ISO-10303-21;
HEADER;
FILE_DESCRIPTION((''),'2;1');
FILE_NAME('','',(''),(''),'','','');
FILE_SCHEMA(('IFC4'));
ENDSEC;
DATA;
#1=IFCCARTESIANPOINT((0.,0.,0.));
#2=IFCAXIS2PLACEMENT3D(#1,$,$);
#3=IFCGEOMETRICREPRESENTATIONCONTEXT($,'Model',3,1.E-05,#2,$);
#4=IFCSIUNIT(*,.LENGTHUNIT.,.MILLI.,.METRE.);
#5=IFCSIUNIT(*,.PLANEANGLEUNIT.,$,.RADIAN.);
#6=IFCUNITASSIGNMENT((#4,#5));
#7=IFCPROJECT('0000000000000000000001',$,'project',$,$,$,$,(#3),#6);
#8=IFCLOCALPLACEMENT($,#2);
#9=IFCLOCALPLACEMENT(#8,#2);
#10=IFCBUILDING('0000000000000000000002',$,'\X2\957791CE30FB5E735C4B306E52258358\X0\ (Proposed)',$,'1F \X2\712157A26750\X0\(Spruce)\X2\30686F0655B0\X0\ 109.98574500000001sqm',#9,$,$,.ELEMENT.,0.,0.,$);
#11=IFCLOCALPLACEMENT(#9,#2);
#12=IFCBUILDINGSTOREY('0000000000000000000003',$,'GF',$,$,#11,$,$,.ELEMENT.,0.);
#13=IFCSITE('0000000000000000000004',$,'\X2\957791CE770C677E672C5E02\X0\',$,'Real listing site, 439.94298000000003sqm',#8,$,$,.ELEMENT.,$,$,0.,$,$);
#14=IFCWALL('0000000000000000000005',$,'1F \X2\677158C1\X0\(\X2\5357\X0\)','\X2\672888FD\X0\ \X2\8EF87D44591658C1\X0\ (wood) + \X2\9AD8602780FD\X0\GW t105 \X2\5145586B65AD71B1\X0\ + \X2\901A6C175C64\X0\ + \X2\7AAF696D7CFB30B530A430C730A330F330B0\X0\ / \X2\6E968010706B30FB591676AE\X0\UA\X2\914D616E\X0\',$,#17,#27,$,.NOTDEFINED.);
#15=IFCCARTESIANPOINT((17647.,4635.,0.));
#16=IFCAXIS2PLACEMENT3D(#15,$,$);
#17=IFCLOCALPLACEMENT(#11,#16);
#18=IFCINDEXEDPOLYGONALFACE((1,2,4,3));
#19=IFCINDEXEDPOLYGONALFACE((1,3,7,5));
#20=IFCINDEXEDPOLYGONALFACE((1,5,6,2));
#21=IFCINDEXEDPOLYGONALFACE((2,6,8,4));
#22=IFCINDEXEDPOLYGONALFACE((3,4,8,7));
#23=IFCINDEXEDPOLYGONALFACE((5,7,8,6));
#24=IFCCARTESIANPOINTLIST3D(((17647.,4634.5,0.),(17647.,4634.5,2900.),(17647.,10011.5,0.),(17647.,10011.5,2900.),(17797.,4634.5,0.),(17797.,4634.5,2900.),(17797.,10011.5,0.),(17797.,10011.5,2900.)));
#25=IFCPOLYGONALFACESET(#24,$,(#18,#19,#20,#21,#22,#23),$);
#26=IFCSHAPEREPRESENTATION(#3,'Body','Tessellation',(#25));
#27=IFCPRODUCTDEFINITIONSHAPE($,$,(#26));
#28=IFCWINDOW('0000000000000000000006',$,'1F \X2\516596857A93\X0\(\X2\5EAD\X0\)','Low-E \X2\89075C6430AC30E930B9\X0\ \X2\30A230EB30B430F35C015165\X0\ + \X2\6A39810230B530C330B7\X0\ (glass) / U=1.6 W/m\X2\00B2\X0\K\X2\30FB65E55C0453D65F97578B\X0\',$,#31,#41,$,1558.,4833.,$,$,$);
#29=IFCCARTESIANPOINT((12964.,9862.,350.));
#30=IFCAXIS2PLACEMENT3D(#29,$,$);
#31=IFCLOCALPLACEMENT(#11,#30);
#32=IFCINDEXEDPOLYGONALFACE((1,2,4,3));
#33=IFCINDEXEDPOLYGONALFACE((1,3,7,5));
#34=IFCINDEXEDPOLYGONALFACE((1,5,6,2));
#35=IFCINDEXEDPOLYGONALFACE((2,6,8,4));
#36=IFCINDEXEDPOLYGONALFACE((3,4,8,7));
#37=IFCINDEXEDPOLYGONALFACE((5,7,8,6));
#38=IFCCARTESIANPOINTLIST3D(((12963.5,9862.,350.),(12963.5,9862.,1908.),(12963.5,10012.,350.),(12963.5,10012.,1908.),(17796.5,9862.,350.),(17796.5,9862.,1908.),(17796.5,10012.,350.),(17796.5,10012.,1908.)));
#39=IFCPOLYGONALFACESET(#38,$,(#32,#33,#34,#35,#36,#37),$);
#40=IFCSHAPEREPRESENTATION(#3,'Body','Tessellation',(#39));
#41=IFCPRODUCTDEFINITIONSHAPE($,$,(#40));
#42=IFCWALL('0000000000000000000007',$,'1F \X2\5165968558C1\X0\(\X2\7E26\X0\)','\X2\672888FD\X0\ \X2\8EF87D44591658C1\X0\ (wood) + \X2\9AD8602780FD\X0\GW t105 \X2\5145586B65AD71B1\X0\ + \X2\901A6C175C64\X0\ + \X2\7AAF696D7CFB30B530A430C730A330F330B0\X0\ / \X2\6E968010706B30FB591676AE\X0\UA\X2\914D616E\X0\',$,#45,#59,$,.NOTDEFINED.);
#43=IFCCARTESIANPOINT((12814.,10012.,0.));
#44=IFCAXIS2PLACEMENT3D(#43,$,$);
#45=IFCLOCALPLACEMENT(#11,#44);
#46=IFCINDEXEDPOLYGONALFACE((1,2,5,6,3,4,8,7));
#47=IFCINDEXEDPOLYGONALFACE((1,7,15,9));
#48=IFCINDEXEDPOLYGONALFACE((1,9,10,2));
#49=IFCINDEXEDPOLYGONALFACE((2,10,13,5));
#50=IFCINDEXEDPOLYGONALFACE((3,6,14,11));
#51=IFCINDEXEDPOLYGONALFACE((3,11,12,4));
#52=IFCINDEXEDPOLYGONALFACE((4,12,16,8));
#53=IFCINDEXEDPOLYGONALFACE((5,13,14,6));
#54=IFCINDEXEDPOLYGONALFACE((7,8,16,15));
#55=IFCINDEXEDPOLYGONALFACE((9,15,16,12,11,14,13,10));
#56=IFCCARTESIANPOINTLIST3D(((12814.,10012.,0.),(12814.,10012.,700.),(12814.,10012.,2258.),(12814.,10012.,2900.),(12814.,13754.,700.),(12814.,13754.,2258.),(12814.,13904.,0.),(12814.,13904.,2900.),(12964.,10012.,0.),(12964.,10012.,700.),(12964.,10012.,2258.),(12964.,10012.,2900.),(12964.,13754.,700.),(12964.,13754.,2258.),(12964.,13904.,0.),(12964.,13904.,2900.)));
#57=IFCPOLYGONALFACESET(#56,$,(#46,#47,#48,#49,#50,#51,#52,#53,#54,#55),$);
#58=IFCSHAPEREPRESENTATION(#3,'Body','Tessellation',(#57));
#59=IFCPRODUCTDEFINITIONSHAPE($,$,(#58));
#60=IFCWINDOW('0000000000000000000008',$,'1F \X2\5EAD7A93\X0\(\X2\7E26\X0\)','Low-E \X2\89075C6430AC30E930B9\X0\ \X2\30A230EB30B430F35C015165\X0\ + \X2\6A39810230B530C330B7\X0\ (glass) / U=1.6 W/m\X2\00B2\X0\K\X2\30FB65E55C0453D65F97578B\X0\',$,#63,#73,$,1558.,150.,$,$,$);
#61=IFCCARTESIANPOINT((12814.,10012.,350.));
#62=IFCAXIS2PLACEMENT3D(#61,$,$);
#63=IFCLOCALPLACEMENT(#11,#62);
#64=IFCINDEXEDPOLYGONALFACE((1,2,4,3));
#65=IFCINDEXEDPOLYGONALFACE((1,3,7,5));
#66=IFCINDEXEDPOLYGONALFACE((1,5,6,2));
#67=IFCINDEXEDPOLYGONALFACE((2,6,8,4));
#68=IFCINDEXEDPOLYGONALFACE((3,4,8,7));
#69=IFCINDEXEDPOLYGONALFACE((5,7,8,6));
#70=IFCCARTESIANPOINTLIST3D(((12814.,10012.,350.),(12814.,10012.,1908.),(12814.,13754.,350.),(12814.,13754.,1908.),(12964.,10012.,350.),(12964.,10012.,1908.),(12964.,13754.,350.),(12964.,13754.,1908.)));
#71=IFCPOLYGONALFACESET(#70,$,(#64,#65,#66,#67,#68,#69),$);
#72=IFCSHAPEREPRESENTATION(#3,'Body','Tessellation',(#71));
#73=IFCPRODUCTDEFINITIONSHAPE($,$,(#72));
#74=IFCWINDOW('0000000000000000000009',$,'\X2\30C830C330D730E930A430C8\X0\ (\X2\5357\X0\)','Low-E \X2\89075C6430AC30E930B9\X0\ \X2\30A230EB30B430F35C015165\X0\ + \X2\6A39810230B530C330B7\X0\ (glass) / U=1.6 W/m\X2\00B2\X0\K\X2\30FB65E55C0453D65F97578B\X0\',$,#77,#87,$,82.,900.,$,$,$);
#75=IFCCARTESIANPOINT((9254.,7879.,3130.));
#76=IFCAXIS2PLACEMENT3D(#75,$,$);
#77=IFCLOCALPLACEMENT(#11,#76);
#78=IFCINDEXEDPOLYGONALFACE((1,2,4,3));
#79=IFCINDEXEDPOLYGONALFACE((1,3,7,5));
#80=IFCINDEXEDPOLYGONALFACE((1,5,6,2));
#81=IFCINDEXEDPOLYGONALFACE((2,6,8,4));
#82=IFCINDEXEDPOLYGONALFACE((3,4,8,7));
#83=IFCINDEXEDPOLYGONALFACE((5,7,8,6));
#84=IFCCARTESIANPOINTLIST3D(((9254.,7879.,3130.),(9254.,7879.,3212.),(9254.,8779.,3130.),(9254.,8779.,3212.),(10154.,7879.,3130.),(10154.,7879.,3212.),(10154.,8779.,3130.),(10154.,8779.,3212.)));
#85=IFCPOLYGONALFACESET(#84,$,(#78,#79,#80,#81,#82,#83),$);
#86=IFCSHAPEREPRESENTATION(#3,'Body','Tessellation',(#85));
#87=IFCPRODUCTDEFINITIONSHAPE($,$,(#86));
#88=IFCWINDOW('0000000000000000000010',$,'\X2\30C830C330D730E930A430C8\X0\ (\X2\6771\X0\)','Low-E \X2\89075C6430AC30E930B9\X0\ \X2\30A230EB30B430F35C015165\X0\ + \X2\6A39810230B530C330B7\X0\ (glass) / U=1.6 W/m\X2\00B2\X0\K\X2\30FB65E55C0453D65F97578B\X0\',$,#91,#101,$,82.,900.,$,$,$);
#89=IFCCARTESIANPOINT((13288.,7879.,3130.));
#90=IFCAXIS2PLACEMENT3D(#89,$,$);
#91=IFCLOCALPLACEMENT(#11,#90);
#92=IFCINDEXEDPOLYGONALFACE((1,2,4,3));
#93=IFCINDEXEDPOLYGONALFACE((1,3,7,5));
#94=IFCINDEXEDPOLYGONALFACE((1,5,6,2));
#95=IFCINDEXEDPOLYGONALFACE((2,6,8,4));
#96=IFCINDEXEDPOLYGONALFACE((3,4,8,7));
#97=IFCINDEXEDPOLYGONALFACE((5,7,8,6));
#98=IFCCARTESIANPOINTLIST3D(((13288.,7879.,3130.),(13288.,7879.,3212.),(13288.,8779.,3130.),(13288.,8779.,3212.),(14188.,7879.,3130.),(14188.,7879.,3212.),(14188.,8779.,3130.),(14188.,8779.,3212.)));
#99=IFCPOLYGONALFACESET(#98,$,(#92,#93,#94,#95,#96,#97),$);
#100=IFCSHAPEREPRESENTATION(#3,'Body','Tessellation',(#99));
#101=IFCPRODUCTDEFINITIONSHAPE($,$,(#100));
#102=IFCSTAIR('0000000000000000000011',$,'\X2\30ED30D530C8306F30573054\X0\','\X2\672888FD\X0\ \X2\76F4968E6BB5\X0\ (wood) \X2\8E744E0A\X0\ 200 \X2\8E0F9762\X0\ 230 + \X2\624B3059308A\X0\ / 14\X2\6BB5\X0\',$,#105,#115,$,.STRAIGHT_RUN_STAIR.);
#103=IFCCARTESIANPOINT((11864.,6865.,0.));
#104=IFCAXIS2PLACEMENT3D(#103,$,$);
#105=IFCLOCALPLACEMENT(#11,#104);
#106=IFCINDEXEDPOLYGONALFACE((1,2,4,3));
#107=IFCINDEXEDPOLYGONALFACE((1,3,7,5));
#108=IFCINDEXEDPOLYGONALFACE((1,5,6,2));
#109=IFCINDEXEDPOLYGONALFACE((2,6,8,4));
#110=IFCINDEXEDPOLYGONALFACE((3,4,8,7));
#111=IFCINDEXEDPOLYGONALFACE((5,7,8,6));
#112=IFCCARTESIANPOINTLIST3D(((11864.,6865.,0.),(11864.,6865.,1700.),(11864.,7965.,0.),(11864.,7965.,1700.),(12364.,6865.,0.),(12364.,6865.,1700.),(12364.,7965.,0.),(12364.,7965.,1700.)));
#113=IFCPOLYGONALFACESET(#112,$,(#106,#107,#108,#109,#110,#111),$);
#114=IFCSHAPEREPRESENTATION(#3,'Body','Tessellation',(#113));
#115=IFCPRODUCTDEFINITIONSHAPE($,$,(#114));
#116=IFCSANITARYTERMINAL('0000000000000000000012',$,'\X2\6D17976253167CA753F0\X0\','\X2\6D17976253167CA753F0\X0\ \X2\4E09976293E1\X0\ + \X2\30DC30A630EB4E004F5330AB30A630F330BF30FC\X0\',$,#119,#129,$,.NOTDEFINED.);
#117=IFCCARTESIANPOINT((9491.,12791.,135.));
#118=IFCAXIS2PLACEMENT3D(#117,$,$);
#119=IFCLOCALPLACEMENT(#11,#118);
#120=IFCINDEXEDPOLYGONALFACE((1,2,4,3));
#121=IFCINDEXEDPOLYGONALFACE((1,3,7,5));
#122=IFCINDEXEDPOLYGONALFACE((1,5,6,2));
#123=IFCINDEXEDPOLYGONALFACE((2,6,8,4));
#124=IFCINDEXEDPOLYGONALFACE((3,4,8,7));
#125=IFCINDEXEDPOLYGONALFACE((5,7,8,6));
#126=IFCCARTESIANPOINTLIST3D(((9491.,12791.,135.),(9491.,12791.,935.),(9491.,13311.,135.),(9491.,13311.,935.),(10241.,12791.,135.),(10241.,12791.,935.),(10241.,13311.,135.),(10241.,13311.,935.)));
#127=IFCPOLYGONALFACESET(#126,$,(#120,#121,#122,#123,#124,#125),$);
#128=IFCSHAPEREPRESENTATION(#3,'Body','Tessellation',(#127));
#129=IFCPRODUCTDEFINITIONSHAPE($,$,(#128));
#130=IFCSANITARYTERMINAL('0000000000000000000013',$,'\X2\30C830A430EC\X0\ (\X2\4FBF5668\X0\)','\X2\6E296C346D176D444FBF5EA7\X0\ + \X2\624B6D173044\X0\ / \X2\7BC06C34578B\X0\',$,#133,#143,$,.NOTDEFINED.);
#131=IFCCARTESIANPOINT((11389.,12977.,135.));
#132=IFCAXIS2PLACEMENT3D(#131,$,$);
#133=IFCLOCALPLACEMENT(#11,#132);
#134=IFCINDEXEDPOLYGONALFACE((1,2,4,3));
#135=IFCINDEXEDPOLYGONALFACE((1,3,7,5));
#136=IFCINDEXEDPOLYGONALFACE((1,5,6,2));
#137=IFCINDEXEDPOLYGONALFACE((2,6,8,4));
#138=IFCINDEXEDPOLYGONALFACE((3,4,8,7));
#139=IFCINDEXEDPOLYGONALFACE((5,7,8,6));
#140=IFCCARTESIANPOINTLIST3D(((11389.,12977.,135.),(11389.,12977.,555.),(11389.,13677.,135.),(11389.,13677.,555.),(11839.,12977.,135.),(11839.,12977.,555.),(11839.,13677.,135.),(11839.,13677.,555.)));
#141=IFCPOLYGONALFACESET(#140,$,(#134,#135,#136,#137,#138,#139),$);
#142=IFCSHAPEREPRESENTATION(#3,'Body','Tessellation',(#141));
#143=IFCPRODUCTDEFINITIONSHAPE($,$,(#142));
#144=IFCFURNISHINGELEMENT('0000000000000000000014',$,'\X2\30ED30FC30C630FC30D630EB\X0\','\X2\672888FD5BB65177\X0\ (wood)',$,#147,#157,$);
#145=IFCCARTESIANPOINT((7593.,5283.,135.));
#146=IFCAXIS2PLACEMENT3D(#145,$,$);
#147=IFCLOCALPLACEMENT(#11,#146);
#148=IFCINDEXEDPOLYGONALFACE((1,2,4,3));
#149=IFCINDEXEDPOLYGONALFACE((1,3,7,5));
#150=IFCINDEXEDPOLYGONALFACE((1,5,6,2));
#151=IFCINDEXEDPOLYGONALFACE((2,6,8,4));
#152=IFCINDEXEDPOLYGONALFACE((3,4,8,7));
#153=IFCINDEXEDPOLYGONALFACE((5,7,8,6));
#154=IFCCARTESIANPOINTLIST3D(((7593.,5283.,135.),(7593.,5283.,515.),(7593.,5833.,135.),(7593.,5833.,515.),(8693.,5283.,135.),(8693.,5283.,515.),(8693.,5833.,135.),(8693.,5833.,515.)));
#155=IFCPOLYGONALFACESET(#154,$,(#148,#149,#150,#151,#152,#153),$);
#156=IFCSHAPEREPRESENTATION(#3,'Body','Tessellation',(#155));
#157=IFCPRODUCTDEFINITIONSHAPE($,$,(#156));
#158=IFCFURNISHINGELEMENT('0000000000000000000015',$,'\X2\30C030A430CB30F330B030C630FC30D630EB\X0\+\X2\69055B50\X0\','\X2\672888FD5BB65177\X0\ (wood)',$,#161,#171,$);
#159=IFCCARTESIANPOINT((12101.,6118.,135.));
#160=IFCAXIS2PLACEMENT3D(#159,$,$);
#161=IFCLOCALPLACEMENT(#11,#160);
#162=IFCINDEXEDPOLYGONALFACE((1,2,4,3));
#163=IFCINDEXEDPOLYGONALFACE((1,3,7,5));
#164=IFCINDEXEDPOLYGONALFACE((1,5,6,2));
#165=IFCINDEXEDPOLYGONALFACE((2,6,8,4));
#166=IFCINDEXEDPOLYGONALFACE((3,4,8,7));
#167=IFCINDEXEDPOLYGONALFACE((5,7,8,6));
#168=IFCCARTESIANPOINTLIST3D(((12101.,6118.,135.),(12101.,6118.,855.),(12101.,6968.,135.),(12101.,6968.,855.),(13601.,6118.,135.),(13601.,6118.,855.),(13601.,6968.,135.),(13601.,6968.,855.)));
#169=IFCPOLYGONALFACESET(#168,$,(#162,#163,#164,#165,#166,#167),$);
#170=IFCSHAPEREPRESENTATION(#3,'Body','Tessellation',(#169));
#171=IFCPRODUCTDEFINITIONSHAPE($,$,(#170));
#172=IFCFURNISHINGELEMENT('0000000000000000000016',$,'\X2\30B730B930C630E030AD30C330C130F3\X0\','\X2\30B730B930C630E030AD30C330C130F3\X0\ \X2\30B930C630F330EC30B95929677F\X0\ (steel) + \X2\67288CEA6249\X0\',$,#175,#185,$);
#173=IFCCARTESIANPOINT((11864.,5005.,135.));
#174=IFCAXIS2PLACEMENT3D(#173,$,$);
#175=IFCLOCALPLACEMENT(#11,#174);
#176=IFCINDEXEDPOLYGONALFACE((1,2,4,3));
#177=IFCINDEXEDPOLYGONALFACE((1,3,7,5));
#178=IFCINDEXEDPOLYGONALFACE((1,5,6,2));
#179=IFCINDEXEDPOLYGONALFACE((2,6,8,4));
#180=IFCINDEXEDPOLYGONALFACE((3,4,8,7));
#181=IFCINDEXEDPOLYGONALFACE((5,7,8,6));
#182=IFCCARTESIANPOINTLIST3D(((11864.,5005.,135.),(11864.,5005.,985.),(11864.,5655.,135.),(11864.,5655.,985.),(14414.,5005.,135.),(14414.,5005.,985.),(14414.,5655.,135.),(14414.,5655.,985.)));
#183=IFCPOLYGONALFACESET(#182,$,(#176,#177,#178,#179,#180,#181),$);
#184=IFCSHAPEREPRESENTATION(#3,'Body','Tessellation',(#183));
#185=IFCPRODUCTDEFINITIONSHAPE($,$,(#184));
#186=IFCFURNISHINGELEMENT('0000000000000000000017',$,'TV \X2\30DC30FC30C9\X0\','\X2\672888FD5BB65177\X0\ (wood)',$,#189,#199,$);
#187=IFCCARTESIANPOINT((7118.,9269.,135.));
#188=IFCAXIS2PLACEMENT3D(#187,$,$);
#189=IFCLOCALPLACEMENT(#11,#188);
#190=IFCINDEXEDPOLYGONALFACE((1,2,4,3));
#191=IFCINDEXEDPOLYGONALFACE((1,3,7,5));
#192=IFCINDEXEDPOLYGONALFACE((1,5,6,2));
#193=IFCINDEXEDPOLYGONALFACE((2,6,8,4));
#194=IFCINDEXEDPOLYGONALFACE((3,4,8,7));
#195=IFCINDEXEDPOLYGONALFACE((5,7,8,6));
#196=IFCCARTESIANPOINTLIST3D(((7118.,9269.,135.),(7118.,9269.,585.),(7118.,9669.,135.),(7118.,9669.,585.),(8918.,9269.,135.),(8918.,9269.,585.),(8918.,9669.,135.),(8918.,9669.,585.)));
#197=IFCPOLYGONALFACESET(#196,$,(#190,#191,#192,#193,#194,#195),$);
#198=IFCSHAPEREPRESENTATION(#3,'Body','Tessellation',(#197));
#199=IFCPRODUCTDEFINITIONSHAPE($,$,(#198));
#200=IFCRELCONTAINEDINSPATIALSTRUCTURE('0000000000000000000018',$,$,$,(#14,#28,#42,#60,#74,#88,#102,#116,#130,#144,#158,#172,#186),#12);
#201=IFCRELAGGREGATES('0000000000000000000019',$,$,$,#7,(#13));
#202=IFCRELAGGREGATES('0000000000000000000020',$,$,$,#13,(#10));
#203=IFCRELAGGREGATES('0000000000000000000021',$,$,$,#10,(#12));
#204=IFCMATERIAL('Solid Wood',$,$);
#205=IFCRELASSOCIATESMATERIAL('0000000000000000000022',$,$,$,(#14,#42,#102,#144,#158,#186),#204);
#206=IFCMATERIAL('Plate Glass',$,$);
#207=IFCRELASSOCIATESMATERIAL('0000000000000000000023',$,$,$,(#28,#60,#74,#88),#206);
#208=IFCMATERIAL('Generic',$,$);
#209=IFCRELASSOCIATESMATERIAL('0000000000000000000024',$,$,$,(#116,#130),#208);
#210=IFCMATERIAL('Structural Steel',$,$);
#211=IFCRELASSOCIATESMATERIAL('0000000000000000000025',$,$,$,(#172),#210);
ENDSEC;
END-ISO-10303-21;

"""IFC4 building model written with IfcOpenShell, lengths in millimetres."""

from ifc_helpers import new_model, si_unit, frame, frame_2d, origin, place, context, project, spatial, rectangle, extrude, material, element, fill, save


model = new_model("IFC4")

# Units and contexts
model_context = context("Model", 3, precision=1e-05, world=origin())
ifc_project = project(units=[si_unit("LENGTHUNIT", "METRE", prefix="MILLI"), si_unit("PLANEANGLEUNIT", "RADIAN")], contexts=[model_context])

# Site, building, storey
site_placement = place(None, origin())
site = spatial("IfcSite", under=ifc_project, at=site_placement, Name="長野県松本市", ObjectType="Real listing site, 439.94298000000003sqm", CompositionType="ELEMENT", RefElevation=0.0)
building_placement = place(site_placement, origin())
building = spatial("IfcBuilding", under=site, at=building_placement, Name="長野・平屋の別荘 (Proposed)", ObjectType="1F 無垢材(Spruce)と漆喰 109.98574500000001sqm", CompositionType="ELEMENT", ElevationOfRefHeight=0.0, ElevationOfTerrain=0.0)
storey_placement = place(building_placement, origin())
storey = spatial("IfcBuildingStorey", under=building, at=storey_placement, Name="GF", CompositionType="ELEMENT", Elevation=0.0)

# Shared definitions
ifc_material_1 = material(Name="Solid Wood")

# Wall, opening, window
wall_1_placement = place(storey_placement, frame((17647.0, 4635.0, 0.0)))
wall_1 = element("IfcWall", 1, at=wall_1_placement, inside=storey, material=ifc_material_1, Name="1F 東壁(南)", Description="木製 軸組外壁 (wood) + 高性能GW t105 充填断熱 + 通気層 + 窯業系サイディング / 準耐火・外皮UA配慮", PredefinedType="NOTDEFINED", context=model_context, shape_type="SweptSolid", body=[
    extrude(rectangle(XDim=150.0, YDim=5377.0, at=frame_2d((75.0, 2688.0))), frame((17647.0, 4635.0, 0.0)), (0.0, 0.0, 1.0), 2900.0),
])
opening_1_placement = place(storey_placement, frame((12964.0, 9862.0, 350.0)))
opening_1 = element("IfcOpeningElement", 2, at=opening_1_placement, cuts=wall_1, PredefinedType="NOTDEFINED", context=model_context, shape_type="SweptSolid", body=[
    extrude(rectangle(XDim=4833.0, YDim=150.0, at=frame_2d((2416.0, 75.0))), frame((12964.0, 9862.0, 350.0)), (0.0, 0.0, 1.0), 1558.0),
])
ifc_material_2 = material(Name="Plate Glass")
window_1_placement = place(storey_placement, frame((12964.0, 9862.0, 350.0)))
window_1 = element("IfcWindow", 3, at=window_1_placement, inside=storey, material=ifc_material_2, Name="1F 入隅窓(庭)", Description="Low-E 複層ガラス アルゴン封入 + 樹脂サッシ (glass) / U=1.6 W/m²K・日射取得型", OverallHeight=1558.0, OverallWidth=4833.0, context=model_context, shape_type="SweptSolid", body=[
    extrude(rectangle(XDim=4833.0, YDim=150.0, at=frame_2d((2416.0, 75.0))), frame((12964.0, 9862.0, 350.0)), (0.0, 0.0, 1.0), 1558.0),
])
fill(opening_1, window_1)

# Wall, opening, window
wall_2_placement = place(storey_placement, frame((12814.0, 10012.0, 0.0)))
wall_2 = element("IfcWall", 4, at=wall_2_placement, inside=storey, material=ifc_material_1, Name="1F 入隅壁(縦)", Description="木製 軸組外壁 (wood) + 高性能GW t105 充填断熱 + 通気層 + 窯業系サイディング / 準耐火・外皮UA配慮", PredefinedType="NOTDEFINED", context=model_context, shape_type="SweptSolid", body=[
    extrude(rectangle(XDim=150.0, YDim=3892.0, at=frame_2d((75.0, 1946.0))), frame((12814.0, 10012.0, 0.0)), (0.0, 0.0, 1.0), 2900.0),
])
opening_2_placement = place(storey_placement, frame((12814.0, 10012.0, 350.0)))
opening_2 = element("IfcOpeningElement", 5, at=opening_2_placement, cuts=wall_2, PredefinedType="NOTDEFINED", context=model_context, shape_type="SweptSolid", body=[
    extrude(rectangle(XDim=150.0, YDim=3742.0, at=frame_2d((75.0, 1871.0))), frame((12814.0, 10012.0, 350.0)), (0.0, 0.0, 1.0), 1558.0),
])
window_2_placement = place(storey_placement, frame((12814.0, 10012.0, 350.0)))
window_2 = element("IfcWindow", 6, at=window_2_placement, inside=storey, material=ifc_material_2, Name="1F 庭窓(縦)", Description="Low-E 複層ガラス アルゴン封入 + 樹脂サッシ (glass) / U=1.6 W/m²K・日射取得型", OverallHeight=1558.0, OverallWidth=150.0, context=model_context, shape_type="SweptSolid", body=[
    extrude(rectangle(XDim=150.0, YDim=3742.0, at=frame_2d((75.0, 1871.0))), frame((12814.0, 10012.0, 350.0)), (0.0, 0.0, 1.0), 1558.0),
])
fill(opening_2, window_2)

# Windows
window_3_placement = place(storey_placement, frame((9254.0, 7879.0, 3130.0)))
element("IfcWindow", 7, at=window_3_placement, inside=storey, material=ifc_material_2, Name="トップライト (南)", Description="Low-E 複層ガラス アルゴン封入 + 樹脂サッシ (glass) / U=1.6 W/m²K・日射取得型", OverallHeight=82.0, OverallWidth=900.0, context=model_context, shape_type="SweptSolid", body=[
    extrude(rectangle(XDim=900.0, YDim=900.0, at=frame_2d((450.0, 450.0))), frame((9254.0, 7879.0, 3130.0)), (0.0, 0.0, 1.0), 82.0),
])
window_4_placement = place(storey_placement, frame((13288.0, 7879.0, 3130.0)))
element("IfcWindow", 8, at=window_4_placement, inside=storey, material=ifc_material_2, Name="トップライト (東)", Description="Low-E 複層ガラス アルゴン封入 + 樹脂サッシ (glass) / U=1.6 W/m²K・日射取得型", OverallHeight=82.0, OverallWidth=900.0, context=model_context, shape_type="SweptSolid", body=[
    extrude(rectangle(XDim=900.0, YDim=900.0, at=frame_2d((450.0, 450.0))), frame((13288.0, 7879.0, 3130.0)), (0.0, 0.0, 1.0), 82.0),
])

# Stair
stair_placement = place(storey_placement, frame((11864.0, 6865.0, 0.0)))
element("IfcStair", 9, at=stair_placement, inside=storey, material=ifc_material_1, Name="ロフトはしご", Description="木製 直階段 (wood) 蹴上 200 踏面 230 + 手すり / 14段", PredefinedType="STRAIGHT_RUN_STAIR", context=model_context, shape_type="SweptSolid", body=[
    extrude(rectangle(XDim=500.0, YDim=1100.0, at=frame_2d((250.0, 550.0))), frame((11864.0, 6865.0, 0.0)), (0.0, 0.0, 1.0), 1700.0),
])

# Sanitary terminals
ifc_material_3 = material(Name="Generic")
sanitary_terminal_1_placement = place(storey_placement, frame((9491.0, 12791.0, 135.0)))
element("IfcSanitaryTerminal", 10, at=sanitary_terminal_1_placement, inside=storey, material=ifc_material_3, Name="洗面化粧台", Description="洗面化粧台 三面鏡 + ボウル一体カウンター", PredefinedType="NOTDEFINED", context=model_context, shape_type="SweptSolid", body=[
    extrude(rectangle(XDim=750.0, YDim=520.0, at=frame_2d((375.0, 260.0))), frame((9491.0, 12791.0, 135.0)), (0.0, 0.0, 1.0), 800.0),
])
sanitary_terminal_2_placement = place(storey_placement, frame((11389.0, 12977.0, 135.0)))
element("IfcSanitaryTerminal", 11, at=sanitary_terminal_2_placement, inside=storey, material=ifc_material_3, Name="トイレ (便器)", Description="温水洗浄便座 + 手洗い / 節水型", PredefinedType="NOTDEFINED", context=model_context, shape_type="SweptSolid", body=[
    extrude(rectangle(XDim=450.0, YDim=700.0, at=frame_2d((225.0, 350.0))), frame((11389.0, 12977.0, 135.0)), (0.0, 0.0, 1.0), 420.0),
])

# Furnishing elements
furnishing_1_placement = place(storey_placement, frame((7593.0, 5283.0, 135.0)))
element("IfcFurnishingElement", 12, at=furnishing_1_placement, inside=storey, material=ifc_material_1, Name="ローテーブル", Description="木製家具 (wood)", context=model_context, shape_type="SweptSolid", body=[
    extrude(rectangle(XDim=1100.0, YDim=550.0, at=frame_2d((550.0, 275.0))), frame((7593.0, 5283.0, 135.0)), (0.0, 0.0, 1.0), 380.0),
])
furnishing_2_placement = place(storey_placement, frame((12101.0, 6118.0, 135.0)))
element("IfcFurnishingElement", 13, at=furnishing_2_placement, inside=storey, material=ifc_material_1, Name="ダイニングテーブル+椅子", Description="木製家具 (wood)", context=model_context, shape_type="SweptSolid", body=[
    extrude(rectangle(XDim=1500.0, YDim=850.0, at=frame_2d((750.0, 425.0))), frame((12101.0, 6118.0, 135.0)), (0.0, 0.0, 1.0), 720.0),
])
ifc_material_4 = material(Name="Structural Steel")
furnishing_3_placement = place(storey_placement, frame((11864.0, 5005.0, 135.0)))
element("IfcFurnishingElement", 14, at=furnishing_3_placement, inside=storey, material=ifc_material_4, Name="システムキッチン", Description="システムキッチン ステンレス天板 (steel) + 木質扉", context=model_context, shape_type="SweptSolid", body=[
    extrude(rectangle(XDim=2550.0, YDim=650.0, at=frame_2d((1275.0, 325.0))), frame((11864.0, 5005.0, 135.0)), (0.0, 0.0, 1.0), 850.0),
])
furnishing_4_placement = place(storey_placement, frame((7118.0, 9269.0, 135.0)))
element("IfcFurnishingElement", 15, at=furnishing_4_placement, inside=storey, material=ifc_material_1, Name="TV ボード", Description="木製家具 (wood)", context=model_context, shape_type="SweptSolid", body=[
    extrude(rectangle(XDim=1800.0, YDim=400.0, at=frame_2d((900.0, 200.0))), frame((7118.0, 9269.0, 135.0)), (0.0, 0.0, 1.0), 450.0),
])

save(model, "model.ifc")
